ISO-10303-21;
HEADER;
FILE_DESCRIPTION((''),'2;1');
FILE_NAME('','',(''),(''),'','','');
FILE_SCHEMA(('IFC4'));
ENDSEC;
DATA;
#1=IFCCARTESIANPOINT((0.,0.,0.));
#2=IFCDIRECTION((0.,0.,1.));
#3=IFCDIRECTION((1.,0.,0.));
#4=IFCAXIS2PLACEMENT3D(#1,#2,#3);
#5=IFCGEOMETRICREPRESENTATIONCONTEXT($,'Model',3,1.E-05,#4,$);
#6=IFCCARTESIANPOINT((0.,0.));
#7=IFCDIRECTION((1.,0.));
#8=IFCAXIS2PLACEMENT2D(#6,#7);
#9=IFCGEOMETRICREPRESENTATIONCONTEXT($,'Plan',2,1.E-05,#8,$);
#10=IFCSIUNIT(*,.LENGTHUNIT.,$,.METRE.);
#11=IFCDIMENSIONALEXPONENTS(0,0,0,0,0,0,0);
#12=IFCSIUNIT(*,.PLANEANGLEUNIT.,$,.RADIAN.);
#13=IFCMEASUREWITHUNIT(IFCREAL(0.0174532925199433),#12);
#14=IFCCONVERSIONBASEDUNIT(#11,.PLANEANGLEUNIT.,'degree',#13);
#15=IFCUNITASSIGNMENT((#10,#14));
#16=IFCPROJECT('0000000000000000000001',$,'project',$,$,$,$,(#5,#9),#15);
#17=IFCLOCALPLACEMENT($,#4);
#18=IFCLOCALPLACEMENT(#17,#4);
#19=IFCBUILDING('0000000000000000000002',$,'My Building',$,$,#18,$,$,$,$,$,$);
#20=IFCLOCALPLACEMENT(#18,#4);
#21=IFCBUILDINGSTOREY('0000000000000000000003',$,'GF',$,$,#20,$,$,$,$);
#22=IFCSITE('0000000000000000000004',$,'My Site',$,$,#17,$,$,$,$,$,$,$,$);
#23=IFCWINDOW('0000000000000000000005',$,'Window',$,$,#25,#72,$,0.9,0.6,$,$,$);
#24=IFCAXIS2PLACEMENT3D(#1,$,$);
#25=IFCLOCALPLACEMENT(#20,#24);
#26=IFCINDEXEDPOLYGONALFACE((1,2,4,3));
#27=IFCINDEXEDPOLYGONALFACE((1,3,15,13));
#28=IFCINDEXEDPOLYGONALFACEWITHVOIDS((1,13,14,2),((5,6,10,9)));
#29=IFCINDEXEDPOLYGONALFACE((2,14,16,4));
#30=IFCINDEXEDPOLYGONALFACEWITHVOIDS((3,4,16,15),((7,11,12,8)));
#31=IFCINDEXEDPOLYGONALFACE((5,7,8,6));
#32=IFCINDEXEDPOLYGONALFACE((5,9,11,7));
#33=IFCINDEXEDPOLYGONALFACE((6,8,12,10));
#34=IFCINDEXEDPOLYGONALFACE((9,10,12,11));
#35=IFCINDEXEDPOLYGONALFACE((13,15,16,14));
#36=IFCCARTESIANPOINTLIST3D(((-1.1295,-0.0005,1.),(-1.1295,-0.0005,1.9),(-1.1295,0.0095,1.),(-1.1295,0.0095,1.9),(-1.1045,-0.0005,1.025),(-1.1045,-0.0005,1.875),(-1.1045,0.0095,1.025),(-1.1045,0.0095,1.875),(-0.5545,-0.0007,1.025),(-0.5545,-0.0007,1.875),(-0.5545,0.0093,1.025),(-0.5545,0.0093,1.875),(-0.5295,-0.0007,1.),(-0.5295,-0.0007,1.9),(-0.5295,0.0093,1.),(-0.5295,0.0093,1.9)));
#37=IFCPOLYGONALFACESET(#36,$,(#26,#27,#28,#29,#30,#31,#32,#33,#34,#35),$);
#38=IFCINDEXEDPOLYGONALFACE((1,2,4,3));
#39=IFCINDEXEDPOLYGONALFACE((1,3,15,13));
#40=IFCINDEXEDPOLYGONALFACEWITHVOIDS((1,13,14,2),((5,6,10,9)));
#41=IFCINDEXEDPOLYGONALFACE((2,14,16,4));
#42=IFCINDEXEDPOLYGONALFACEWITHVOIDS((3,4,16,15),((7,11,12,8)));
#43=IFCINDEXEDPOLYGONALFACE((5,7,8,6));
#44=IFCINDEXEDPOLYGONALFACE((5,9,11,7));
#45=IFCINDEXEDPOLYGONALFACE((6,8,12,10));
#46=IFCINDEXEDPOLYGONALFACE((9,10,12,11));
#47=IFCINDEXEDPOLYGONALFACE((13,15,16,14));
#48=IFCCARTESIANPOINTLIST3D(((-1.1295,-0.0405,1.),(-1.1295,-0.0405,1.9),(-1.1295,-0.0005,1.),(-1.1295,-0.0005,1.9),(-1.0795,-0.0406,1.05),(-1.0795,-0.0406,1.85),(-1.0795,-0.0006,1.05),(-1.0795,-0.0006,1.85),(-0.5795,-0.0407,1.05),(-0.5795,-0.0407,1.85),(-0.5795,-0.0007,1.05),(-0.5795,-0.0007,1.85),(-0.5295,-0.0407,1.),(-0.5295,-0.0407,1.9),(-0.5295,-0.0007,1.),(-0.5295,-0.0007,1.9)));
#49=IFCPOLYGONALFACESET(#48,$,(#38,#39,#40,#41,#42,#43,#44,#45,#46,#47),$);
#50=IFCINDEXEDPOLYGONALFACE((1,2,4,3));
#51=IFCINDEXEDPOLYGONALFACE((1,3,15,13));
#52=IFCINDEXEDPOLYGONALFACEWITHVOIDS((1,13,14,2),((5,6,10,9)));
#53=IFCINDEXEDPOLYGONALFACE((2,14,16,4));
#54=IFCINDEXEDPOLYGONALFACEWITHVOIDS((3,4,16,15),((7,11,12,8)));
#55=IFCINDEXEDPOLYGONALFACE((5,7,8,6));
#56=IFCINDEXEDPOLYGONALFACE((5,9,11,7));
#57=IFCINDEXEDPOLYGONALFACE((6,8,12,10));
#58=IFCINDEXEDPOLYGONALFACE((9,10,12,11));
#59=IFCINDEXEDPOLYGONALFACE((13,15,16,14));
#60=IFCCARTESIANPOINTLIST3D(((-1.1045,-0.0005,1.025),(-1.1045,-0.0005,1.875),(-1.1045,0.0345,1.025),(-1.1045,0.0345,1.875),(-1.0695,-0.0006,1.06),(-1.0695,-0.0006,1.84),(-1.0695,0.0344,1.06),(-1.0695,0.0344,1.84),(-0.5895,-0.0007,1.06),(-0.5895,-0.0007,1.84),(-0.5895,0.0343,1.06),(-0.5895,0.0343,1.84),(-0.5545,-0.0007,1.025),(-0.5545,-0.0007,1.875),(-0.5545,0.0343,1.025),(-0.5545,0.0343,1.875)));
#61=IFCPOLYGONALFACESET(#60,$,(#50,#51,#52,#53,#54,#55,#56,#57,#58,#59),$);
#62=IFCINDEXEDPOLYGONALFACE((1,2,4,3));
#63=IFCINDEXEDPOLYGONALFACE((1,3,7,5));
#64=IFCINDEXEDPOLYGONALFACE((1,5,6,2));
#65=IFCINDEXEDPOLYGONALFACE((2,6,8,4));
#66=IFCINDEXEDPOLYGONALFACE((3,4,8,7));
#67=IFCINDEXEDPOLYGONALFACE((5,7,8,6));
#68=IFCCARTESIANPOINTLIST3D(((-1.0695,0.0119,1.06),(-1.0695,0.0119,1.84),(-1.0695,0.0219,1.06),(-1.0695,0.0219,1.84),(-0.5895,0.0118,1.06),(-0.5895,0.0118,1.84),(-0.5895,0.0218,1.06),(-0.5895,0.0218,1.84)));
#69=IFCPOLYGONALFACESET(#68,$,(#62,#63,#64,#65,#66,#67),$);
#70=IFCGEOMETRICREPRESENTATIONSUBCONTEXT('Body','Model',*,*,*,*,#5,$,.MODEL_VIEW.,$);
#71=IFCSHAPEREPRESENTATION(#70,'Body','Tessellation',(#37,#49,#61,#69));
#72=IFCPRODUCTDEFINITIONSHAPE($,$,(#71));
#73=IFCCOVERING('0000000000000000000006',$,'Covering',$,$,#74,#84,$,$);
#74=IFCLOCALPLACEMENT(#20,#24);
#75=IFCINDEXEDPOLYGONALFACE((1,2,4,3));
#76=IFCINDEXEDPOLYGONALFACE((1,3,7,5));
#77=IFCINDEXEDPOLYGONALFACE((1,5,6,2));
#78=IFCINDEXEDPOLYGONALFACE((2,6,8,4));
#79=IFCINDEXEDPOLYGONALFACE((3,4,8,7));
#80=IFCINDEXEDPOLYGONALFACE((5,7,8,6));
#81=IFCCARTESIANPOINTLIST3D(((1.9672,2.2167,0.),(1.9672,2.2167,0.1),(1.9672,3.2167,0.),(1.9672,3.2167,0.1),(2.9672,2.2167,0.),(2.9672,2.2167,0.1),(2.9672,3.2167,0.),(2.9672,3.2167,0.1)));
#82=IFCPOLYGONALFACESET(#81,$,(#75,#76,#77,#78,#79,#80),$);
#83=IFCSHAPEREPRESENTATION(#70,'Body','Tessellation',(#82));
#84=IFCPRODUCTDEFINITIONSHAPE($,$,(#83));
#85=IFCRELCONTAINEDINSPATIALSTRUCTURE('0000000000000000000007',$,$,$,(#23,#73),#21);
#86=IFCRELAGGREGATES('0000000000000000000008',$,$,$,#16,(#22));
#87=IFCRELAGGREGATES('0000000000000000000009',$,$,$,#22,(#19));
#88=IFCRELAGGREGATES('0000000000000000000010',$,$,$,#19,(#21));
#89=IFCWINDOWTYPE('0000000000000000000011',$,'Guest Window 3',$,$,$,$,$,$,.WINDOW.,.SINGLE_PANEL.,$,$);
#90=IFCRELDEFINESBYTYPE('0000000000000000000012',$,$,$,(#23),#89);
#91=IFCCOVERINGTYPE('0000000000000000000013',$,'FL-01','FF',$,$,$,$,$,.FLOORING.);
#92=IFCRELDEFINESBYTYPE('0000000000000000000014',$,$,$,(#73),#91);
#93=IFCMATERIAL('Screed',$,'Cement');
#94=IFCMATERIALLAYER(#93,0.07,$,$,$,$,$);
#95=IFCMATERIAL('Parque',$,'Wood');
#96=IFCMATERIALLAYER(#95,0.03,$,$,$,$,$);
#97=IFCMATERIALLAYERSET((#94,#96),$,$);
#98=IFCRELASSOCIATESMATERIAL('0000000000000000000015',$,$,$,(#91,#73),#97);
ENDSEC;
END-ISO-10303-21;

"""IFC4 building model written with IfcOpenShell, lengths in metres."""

from ifc_helpers import new_model, entity, si_unit, converted_unit, frame, origin_with_axes, origin_2d_with_axis, place, context, subcontext, project, spatial, line, indexed_curve, outline, extrude, shape, source, transform, mapped, material, layer, layer_set, layer_usage, type_object, type_shapes, element, save


model = new_model("IFC4")

# Units and contexts
model_context = context("Model", 3, precision=1e-05, world=origin_with_axes())
plan_context = context("Plan", 2, precision=1e-05, world=origin_2d_with_axis())
body_context_1 = subcontext(model_context, "Body", "Model", "MODEL_VIEW")
body_context_2 = subcontext(plan_context, "Body", "Plan", "PLAN_VIEW")
ifc_project = project(units=[si_unit("LENGTHUNIT", "METRE"), converted_unit("PLANEANGLEUNIT", "degree", entity("IfcReal", 0.0174532925199433), si_unit("PLANEANGLEUNIT", "RADIAN"), dimensions=[0, 0, 0, 0, 0, 0, 0])], contexts=[model_context, plan_context])

# Site, building, storey
site_placement = place(None, origin_with_axes())
site = spatial("IfcSite", under=ifc_project, at=site_placement, Name="My Site")
building_placement = place(site_placement, origin_with_axes())
building = spatial("IfcBuilding", under=site, at=building_placement, Name="My Building")
storey_placement = place(building_placement, origin_with_axes())
storey = spatial("IfcBuildingStorey", under=building, at=storey_placement, Name="GF")

# Window
window_type_1 = type_object("IfcWindowType", Name="Guest Window 3", PartitioningType="SINGLE_PANEL", PredefinedType="WINDOW")
shared_shape_1 = source(origin_with_axes(), body_context_1, "Body", "SweptSolid", [
    extrude(outline(indexed_curve([(0.0, 0.0), (0.6, 0.0), (0.6, 0.9), (0.0, 0.9)], segments=[line(1, 2, 3, 4, 1)]), holes=[indexed_curve([(0.025, 0.025), (0.575, 0.025), (0.575, 0.875), (0.025, 0.875)], segments=[line(1, 2, 3, 4, 1)])]), frame((0.0, 0.09, 0.0), z_axis=(0.0, -1.0, 0.0), x_axis=(1.0, 0.0, 0.0)), (0.0, 0.0, -1.0), 0.01),
    extrude(outline(indexed_curve([(0.0, 0.0), (0.6, 0.0), (0.6, 0.9), (0.0, 0.9)], segments=[line(1, 2, 3, 4, 1)]), holes=[indexed_curve([(0.05, 0.05), (0.55, 0.05), (0.55, 0.85), (0.05, 0.85)], segments=[line(1, 2, 3, 4, 1)])]), frame((0.0, 0.05, 0.0), z_axis=(0.0, -1.0, 0.0), x_axis=(1.0, 0.0, 0.0)), (0.0, 0.0, -1.0), 0.04),
    extrude(outline(indexed_curve([(0.0, 0.0), (0.55, 0.0), (0.55, 0.85), (0.0, 0.85)], segments=[line(1, 2, 3, 4, 1)]), holes=[indexed_curve([(0.035, 0.035), (0.515, 0.035), (0.515, 0.815), (0.035, 0.815)], segments=[line(1, 2, 3, 4, 1)])]), frame((0.025, 0.09, 0.025), z_axis=(0.0, -1.0, 0.0), x_axis=(1.0, 0.0, 0.0)), (0.0, 0.0, -1.0), 0.035),
    extrude(outline(indexed_curve([(0.035, 0.035), (0.515, 0.035), (0.515, 0.815), (0.035, 0.815)], segments=[line(1, 2, 3, 4, 1)])), frame((0.025, 0.1025, 0.025), z_axis=(0.0, -1.0, 0.0), x_axis=(1.0, 0.0, 0.0)), (0.0, 0.0, -1.0), 0.01),
])
shared_shape_2 = source(origin_with_axes(), body_context_2, "Body", "Curve2D", [
    entity("IfcIndexedPolyCurve", entity("IfcCartesianPointList2D", [[0.05, 0.05], [0.55, 0.05]])),
    entity("IfcIndexedPolyCurve", entity("IfcCartesianPointList2D", [[0.0, 0.1], [0.025, 0.1], [0.025, 0.09], [0.05, 0.09], [0.05, 0.05], [0.0, 0.05]]), [entity("IfcLineIndex", [1, 2, 3, 4, 5, 6, 1])]),
    entity("IfcIndexedPolyCurve", entity("IfcCartesianPointList2D", [[0.6, 0.1], [0.575, 0.1], [0.575, 0.09], [0.55, 0.09], [0.55, 0.05], [0.6, 0.05]]), [entity("IfcLineIndex", [1, 2, 3, 4, 5, 6, 1])]),
    entity("IfcIndexedPolyCurve", entity("IfcCartesianPointList2D", [[0.025, 0.09], [0.06, 0.09], [0.06, 0.125], [0.025, 0.125]]), [entity("IfcLineIndex", [1, 2, 3, 4, 1])]),
    entity("IfcIndexedPolyCurve", entity("IfcCartesianPointList2D", [[0.575, 0.09], [0.54, 0.09], [0.54, 0.125], [0.575, 0.125]]), [entity("IfcLineIndex", [1, 2, 3, 4, 1])]),
    entity("IfcIndexedPolyCurve", entity("IfcCartesianPointList2D", [[0.06, 0.09], [0.54, 0.09]])),
    entity("IfcIndexedPolyCurve", entity("IfcCartesianPointList2D", [[0.06, 0.125], [0.54, 0.125]])),
    entity("IfcIndexedPolyCurve", entity("IfcCartesianPointList2D", [[0.06, 0.1075], [0.54, 0.1075]])),
])
type_shapes(window_type_1, [shared_shape_1, shared_shape_2])
placement_1 = place(storey_placement, frame((-2.7734, -0.0901, 0.0), z_axis=(0.0, 0.0, 1.0), x_axis=(1.0, -0.000264, 0.0)))
placement_2 = place(placement_1, frame((1.6439, 0.0, 1.0), z_axis=(0.0, 0.0, 1.0), x_axis=(1.0, 0.0, 0.0)))
window_1_placement = place(placement_2, frame((0.0, 0.0, 0.0), z_axis=(0.0, 0.0, 1.0), x_axis=(1.0, 0.0, 0.0)))
element("IfcWindow", 1, at=window_1_placement, inside=storey, type_object=window_type_1, Name="Window", OverallHeight=0.9, OverallWidth=0.6, shapes=[
    shape(body_context_1, "Body", "MappedRepresentation", [mapped(shared_shape_1, transform((0.0, 0.0, 0.0), x_axis=(1.0, 0.0, 0.0), y_axis=(0.0, 1.0, 0.0), z_axis=(0.0, 0.0, 1.0), scale=1.0))]),
    shape(body_context_2, "Body", "MappedRepresentation", [mapped(shared_shape_2, transform((0.0, 0.0, 0.0), x_axis=(1.0, 0.0, 0.0), y_axis=(0.0, 1.0, 0.0), z_axis=(0.0, 0.0, 1.0), scale=1.0))]),
])

# Covering
ifc_material_1 = material(Name="Screed", Category="Cement")
ifc_layer_1 = layer(ifc_material_1, 0.07)
ifc_material_2 = material(Name="Parque", Category="Wood")
ifc_layer_2 = layer(ifc_material_2, 0.03)
ifc_layer_set_1 = layer_set([ifc_layer_1, ifc_layer_2])
ifc_layer_usage_1 = layer_usage(ifc_layer_set_1, "AXIS3", "POSITIVE", 0.0)
covering_type = type_object("IfcCoveringType", Name="FL-01", Description="FF", PredefinedType="FLOORING", material=ifc_layer_set_1)
covering_placement = place(storey_placement, frame((1.9672, 2.2167, 0.0), z_axis=(0.0, 0.0, 1.0), x_axis=(1.0, 0.0, 0.0)))
element("IfcCovering", 2, at=covering_placement, inside=storey, type_object=covering_type, material=ifc_layer_usage_1, Name="Covering", context=body_context_1, shape_type="SweptSolid", body=[
    extrude(outline(indexed_curve([(0.0, 0.0), (1.0, 0.0), (1.0, 1.0), (0.0, 1.0), (0.0, 0.0)])), None, (0.0, 0.0, 1.0), 0.1),
])

save(model, "model.ifc")
